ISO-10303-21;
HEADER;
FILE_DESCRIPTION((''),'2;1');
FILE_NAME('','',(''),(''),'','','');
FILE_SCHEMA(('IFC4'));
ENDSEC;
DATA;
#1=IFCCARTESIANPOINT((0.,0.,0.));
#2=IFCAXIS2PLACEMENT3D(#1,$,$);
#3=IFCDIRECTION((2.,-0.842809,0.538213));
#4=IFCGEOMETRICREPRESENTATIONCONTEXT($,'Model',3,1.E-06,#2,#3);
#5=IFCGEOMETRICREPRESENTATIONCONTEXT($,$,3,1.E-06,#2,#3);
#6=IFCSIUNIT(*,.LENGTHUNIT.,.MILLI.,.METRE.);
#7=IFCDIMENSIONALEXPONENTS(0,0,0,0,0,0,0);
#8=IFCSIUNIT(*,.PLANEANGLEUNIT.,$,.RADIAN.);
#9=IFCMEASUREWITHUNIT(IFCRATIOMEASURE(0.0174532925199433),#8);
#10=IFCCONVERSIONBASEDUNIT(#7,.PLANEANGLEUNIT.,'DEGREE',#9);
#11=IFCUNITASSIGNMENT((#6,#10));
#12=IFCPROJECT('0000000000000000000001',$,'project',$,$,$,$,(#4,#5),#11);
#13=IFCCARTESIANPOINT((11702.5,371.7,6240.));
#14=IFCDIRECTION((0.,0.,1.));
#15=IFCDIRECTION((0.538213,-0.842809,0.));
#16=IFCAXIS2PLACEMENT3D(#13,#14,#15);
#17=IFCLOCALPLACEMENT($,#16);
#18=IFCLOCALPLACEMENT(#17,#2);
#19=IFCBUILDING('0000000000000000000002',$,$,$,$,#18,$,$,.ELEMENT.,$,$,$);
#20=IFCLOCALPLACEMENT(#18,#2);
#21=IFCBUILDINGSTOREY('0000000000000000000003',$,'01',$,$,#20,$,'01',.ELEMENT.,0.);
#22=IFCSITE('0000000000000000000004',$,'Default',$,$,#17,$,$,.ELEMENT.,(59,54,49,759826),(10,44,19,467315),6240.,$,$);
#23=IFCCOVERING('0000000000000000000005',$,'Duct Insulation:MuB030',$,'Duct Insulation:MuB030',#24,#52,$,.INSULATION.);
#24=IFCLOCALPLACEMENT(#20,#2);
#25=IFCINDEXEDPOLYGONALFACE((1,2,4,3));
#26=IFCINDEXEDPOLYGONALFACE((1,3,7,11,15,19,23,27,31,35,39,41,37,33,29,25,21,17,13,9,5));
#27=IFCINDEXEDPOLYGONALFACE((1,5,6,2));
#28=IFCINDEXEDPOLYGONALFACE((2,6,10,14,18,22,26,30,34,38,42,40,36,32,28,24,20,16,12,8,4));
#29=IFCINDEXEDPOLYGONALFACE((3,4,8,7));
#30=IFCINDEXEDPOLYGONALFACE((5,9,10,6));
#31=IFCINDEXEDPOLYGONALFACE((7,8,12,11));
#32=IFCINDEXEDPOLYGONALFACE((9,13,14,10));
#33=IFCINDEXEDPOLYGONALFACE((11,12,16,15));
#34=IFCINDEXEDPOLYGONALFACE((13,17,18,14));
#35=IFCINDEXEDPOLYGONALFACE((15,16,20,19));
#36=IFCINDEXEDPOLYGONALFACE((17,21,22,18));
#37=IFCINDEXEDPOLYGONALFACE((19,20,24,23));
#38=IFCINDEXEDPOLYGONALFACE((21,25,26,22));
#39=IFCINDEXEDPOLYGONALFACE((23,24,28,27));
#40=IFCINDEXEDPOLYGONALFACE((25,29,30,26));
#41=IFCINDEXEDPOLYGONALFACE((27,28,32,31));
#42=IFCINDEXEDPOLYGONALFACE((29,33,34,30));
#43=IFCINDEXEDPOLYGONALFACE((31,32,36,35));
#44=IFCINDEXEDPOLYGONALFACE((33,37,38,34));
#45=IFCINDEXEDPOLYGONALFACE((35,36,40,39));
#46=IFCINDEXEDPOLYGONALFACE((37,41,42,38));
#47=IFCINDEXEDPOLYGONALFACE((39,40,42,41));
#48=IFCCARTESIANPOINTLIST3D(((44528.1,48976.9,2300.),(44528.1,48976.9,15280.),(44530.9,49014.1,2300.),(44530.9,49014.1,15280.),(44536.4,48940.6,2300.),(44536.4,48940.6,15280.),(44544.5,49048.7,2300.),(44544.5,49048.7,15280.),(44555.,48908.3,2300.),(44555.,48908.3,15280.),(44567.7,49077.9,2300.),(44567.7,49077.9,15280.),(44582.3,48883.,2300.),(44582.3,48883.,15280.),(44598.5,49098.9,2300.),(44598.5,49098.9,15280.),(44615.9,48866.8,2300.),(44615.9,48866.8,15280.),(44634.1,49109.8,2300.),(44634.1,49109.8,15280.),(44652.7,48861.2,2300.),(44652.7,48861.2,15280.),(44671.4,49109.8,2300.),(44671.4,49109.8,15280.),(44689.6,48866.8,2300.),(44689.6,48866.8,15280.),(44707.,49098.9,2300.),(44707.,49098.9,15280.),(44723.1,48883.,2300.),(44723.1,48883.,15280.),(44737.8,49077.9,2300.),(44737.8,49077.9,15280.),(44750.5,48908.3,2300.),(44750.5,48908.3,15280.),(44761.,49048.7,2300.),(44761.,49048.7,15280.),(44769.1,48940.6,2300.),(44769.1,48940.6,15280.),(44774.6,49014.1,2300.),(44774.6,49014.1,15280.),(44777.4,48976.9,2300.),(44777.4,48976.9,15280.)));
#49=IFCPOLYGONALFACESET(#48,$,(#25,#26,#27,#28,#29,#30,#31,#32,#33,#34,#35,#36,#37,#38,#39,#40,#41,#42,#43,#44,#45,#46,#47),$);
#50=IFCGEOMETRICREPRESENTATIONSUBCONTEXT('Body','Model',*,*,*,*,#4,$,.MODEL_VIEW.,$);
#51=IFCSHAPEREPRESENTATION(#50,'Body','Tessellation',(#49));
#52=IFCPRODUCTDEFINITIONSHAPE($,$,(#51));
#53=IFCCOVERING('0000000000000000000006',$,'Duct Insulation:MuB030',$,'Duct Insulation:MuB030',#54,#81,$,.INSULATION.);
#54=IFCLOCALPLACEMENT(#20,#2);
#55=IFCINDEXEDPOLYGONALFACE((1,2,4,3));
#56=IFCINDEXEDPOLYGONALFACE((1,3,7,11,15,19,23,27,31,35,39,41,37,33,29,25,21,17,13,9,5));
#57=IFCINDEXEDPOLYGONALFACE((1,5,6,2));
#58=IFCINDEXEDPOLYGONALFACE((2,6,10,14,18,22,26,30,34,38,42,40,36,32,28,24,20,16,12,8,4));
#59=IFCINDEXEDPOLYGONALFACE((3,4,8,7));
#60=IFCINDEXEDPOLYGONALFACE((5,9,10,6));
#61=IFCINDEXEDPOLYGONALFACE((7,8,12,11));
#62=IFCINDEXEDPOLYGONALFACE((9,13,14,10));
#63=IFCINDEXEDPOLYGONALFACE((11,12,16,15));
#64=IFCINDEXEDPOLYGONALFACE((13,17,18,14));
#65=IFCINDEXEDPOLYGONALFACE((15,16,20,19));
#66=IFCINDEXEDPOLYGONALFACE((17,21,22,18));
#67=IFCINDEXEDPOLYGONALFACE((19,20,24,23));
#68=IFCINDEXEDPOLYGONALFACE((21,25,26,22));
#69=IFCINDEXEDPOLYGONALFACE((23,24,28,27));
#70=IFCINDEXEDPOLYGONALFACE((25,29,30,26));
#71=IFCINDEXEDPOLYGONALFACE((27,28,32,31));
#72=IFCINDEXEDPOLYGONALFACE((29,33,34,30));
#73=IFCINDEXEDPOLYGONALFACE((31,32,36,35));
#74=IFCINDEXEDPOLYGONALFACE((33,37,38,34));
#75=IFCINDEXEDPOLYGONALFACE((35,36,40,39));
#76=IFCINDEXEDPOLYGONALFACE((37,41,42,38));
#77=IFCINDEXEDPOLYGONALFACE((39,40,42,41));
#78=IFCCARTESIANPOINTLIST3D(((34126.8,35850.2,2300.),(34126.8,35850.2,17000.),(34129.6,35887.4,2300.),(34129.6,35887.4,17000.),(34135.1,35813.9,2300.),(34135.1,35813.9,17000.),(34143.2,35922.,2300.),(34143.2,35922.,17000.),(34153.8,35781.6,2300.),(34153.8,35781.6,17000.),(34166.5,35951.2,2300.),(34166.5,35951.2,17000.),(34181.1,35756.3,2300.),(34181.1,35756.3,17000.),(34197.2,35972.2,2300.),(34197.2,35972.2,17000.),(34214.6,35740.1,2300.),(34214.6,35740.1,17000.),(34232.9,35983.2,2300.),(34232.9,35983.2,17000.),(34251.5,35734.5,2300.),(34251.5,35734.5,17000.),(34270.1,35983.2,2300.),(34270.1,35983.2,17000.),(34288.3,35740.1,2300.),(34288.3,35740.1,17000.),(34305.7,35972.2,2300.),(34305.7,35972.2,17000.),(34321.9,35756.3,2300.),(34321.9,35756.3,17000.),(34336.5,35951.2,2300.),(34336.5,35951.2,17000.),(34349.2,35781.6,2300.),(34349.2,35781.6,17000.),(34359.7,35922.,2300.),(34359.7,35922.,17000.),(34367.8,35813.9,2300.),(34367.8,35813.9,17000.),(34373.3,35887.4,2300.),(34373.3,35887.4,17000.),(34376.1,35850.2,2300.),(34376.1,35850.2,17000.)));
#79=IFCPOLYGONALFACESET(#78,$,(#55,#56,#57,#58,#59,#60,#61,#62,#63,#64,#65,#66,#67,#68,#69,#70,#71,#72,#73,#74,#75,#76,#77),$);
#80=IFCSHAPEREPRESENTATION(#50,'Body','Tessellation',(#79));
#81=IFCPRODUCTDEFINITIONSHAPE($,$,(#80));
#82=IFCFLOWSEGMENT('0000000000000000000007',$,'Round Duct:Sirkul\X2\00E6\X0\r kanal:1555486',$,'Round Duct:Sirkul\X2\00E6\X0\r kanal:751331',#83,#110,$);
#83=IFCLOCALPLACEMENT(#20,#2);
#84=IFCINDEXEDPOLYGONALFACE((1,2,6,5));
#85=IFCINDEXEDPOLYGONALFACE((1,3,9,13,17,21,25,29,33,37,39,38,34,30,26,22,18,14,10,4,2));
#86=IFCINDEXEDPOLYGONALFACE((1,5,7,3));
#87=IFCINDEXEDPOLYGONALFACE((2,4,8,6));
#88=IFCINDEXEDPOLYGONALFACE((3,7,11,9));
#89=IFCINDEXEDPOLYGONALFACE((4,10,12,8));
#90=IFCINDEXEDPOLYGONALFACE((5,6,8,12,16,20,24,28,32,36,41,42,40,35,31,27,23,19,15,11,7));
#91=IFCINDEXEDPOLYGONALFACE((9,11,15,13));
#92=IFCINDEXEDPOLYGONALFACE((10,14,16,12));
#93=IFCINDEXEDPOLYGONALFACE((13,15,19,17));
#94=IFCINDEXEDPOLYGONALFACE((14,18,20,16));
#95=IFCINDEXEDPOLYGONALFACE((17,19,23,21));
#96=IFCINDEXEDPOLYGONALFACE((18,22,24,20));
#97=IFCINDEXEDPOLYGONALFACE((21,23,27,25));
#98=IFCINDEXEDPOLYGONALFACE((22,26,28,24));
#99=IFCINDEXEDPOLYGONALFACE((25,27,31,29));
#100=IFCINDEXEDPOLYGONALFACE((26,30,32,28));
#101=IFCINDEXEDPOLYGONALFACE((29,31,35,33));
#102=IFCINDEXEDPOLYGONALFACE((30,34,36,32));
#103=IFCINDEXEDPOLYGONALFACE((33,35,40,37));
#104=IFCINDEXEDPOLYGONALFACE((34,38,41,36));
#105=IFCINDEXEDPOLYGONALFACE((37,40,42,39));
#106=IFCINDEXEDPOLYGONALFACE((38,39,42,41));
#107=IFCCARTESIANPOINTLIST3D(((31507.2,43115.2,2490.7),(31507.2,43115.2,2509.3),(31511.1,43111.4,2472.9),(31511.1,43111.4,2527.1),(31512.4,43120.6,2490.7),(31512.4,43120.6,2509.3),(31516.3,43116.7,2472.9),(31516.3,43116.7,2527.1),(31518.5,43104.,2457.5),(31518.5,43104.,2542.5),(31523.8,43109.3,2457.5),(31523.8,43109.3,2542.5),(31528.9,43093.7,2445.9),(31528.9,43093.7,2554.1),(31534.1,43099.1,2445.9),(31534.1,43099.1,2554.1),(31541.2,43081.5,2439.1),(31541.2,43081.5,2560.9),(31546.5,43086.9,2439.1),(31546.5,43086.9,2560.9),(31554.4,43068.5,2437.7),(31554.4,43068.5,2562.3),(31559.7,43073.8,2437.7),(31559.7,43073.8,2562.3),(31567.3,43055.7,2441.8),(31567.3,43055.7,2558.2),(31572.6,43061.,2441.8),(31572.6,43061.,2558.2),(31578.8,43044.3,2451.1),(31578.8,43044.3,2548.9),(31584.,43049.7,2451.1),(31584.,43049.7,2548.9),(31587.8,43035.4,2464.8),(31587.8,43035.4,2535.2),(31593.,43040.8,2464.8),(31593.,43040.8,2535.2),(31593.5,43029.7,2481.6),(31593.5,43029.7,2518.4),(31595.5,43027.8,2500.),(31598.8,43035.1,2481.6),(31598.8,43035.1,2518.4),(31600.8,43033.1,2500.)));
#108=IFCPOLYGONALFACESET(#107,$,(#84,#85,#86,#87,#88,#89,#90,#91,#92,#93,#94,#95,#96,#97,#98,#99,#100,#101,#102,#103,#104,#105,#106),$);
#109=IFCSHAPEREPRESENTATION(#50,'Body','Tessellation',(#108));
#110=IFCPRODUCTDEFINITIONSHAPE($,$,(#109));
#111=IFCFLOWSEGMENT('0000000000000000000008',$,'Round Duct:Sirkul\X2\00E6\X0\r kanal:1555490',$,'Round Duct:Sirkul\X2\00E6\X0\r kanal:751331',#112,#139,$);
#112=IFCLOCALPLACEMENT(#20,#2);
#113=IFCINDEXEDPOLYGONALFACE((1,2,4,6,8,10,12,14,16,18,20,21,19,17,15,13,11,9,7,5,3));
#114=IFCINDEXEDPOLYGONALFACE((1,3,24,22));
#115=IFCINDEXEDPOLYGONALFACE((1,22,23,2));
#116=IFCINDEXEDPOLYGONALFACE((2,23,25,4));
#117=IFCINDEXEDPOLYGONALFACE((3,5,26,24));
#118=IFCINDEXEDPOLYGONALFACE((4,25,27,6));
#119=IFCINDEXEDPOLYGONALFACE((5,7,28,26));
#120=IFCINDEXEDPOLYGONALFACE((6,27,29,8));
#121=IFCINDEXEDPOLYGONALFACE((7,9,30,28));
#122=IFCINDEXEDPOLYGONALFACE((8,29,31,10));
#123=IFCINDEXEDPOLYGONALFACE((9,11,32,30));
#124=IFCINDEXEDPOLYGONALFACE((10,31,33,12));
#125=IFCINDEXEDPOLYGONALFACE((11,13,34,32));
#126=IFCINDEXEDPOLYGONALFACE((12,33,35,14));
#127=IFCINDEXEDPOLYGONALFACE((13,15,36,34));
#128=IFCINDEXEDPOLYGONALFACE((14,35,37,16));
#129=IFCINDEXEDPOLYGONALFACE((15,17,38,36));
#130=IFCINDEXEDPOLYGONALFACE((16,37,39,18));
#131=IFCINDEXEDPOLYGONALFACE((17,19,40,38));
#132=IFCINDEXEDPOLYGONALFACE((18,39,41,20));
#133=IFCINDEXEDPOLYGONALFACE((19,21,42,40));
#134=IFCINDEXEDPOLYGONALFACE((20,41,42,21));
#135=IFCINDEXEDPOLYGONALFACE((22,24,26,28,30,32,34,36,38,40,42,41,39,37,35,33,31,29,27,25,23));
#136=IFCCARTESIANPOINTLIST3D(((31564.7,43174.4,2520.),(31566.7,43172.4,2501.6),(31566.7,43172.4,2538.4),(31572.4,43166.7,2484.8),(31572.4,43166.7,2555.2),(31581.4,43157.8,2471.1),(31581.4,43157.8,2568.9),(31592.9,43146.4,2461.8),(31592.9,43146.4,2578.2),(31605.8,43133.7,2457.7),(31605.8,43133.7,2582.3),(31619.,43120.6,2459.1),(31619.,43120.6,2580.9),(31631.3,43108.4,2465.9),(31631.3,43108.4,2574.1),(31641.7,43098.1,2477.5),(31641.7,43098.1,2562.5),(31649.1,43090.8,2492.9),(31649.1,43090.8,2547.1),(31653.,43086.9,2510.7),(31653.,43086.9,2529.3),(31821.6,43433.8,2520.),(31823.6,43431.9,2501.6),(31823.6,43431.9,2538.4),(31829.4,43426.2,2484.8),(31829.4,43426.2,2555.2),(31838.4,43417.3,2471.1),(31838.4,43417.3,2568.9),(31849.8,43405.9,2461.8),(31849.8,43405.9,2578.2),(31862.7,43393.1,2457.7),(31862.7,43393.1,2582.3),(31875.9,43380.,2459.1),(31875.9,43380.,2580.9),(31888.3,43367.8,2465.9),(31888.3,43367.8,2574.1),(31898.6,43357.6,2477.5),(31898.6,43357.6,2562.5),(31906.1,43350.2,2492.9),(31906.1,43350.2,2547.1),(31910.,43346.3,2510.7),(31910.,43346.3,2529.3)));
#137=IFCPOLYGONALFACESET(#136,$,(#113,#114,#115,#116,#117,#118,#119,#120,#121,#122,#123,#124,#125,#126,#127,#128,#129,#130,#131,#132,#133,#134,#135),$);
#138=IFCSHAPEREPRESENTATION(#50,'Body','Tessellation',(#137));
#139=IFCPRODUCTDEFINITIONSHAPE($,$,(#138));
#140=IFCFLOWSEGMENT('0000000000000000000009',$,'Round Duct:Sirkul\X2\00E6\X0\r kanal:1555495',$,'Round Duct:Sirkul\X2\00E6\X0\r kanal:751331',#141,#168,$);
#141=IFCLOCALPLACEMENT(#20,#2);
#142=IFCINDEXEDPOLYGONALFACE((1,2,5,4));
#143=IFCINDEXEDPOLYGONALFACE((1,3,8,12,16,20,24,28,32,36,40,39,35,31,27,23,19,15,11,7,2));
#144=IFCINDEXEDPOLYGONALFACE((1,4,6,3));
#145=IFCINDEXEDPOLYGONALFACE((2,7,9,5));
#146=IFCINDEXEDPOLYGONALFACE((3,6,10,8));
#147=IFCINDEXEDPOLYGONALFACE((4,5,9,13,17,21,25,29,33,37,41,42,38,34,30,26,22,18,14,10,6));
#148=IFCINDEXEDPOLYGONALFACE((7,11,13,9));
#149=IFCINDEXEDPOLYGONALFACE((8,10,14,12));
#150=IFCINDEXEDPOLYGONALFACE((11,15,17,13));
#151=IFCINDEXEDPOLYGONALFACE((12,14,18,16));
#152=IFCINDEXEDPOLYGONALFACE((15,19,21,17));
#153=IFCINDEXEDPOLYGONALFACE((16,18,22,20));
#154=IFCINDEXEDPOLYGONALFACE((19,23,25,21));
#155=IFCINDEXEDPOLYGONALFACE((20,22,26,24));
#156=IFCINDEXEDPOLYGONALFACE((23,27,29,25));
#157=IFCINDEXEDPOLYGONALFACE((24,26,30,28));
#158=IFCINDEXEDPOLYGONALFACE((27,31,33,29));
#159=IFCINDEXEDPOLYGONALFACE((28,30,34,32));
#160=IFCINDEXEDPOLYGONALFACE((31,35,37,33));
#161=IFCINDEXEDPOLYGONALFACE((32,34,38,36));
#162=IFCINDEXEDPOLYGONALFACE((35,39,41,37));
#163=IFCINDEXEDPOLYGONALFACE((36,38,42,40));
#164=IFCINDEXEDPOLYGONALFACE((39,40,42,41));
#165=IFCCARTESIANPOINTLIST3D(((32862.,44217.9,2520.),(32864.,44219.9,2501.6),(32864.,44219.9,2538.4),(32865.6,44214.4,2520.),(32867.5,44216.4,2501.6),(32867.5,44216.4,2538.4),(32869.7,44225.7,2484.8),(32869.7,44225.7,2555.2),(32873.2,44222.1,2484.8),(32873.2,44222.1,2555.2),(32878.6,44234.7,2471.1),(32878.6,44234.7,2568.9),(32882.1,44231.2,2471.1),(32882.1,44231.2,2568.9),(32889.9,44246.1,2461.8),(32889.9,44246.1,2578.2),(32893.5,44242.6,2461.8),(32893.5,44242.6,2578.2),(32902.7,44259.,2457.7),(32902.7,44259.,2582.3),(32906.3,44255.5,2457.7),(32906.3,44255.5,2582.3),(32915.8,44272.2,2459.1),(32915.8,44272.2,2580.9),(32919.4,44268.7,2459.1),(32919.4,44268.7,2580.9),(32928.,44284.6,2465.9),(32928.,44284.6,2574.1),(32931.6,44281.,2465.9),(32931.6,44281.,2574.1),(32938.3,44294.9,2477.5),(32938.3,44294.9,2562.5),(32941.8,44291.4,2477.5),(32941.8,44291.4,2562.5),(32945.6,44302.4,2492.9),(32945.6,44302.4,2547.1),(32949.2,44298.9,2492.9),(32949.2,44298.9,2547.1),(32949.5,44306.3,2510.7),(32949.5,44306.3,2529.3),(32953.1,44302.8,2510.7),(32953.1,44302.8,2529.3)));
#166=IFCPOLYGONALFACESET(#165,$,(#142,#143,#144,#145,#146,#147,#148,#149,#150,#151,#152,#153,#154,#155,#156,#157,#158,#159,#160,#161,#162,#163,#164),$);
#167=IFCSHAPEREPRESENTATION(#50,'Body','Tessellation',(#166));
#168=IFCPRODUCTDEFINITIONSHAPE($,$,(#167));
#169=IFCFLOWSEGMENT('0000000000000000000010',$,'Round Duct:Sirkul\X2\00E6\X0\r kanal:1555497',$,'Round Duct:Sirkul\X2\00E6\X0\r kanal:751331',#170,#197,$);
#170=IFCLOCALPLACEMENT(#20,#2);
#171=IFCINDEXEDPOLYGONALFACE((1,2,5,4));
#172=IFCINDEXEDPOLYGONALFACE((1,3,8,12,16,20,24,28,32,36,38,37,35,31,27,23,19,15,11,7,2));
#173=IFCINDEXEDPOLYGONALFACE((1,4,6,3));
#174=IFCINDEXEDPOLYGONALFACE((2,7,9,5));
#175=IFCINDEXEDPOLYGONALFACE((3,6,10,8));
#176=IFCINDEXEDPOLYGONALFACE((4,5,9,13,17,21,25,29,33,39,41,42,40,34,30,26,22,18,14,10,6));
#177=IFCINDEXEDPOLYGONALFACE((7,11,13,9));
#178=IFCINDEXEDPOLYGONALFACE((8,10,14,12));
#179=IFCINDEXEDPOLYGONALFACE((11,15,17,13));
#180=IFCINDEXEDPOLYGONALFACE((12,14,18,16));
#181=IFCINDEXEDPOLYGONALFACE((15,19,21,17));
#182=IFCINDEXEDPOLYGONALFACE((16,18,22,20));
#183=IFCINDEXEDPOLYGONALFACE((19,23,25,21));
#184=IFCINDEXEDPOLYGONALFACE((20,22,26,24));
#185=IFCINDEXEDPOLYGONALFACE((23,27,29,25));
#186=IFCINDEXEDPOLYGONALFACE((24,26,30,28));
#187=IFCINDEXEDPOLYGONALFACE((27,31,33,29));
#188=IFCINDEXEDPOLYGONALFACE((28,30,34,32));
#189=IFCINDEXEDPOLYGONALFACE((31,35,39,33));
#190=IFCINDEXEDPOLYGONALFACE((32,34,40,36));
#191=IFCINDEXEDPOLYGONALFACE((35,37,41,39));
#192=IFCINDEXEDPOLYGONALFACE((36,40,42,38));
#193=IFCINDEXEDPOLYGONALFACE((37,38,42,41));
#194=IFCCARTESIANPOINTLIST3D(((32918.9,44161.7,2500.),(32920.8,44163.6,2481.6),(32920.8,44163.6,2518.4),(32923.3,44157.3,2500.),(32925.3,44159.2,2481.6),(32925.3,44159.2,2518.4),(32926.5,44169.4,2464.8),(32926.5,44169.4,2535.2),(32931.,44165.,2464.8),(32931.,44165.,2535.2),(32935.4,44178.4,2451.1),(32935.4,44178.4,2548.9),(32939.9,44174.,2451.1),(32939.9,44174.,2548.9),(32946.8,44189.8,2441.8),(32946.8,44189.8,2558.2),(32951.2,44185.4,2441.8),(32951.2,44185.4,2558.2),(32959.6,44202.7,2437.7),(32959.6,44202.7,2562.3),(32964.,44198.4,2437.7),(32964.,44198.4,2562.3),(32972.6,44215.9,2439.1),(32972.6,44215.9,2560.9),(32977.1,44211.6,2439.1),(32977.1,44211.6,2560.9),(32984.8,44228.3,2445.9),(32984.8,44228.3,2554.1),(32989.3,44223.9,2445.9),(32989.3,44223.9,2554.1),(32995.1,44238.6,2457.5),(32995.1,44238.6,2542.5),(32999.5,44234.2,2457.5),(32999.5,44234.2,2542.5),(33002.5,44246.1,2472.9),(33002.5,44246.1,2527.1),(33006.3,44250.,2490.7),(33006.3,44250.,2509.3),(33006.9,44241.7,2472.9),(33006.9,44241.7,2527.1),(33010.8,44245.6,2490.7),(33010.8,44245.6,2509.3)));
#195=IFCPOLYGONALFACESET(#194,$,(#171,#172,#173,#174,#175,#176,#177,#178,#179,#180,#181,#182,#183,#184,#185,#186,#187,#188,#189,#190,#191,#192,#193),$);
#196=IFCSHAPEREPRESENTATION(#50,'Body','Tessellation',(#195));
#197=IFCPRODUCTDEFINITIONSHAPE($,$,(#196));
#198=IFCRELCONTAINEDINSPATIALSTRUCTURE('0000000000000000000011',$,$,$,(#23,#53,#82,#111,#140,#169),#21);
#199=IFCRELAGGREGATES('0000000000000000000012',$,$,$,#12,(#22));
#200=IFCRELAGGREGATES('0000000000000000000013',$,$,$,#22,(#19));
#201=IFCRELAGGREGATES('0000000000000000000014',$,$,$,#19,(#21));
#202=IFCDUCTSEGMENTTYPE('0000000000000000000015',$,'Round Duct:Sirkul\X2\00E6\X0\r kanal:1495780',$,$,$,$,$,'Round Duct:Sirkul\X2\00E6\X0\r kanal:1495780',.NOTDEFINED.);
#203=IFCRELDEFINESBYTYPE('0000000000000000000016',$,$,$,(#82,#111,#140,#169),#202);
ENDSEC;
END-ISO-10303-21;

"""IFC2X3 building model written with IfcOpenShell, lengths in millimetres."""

from ifc_helpers import new_model, entity, si_unit, converted_unit, direction, frame, origin, origin_2d_with_axis, place, context, subcontext, project, spatial, circle, extrude, type_object, element, save


model = new_model("IFC2X3")

# Units and contexts
model_context = context("Model", 3, precision=1e-06, world=origin(), true_north=direction((2.0, -0.842809, 0.538213)))
context_of_model = context(None, 3, precision=1e-06, world=origin(), true_north=direction((2.0, -0.842809, 0.538213)))
body_context = subcontext(model_context, "Body", "Model", "MODEL_VIEW")
ifc_project = project(units=[si_unit("LENGTHUNIT", "METRE", prefix="MILLI"), converted_unit("PLANEANGLEUNIT", "DEGREE", entity("IfcRatioMeasure", 0.0174532925199433), si_unit("PLANEANGLEUNIT", "RADIAN"), dimensions=[0, 0, 0, 0, 0, 0, 0])], contexts=[model_context, context_of_model])

# Site, building, storey
site_placement = place(None, frame((11702.5, 371.7, 6240.0), z_axis=(0.0, 0.0, 1.0), x_axis=(0.538213, -0.842809, 0.0)))
site = spatial("IfcSite", under=ifc_project, at=site_placement, Name="Default", CompositionType="ELEMENT", RefLatitude=(59, 54, 49, 759826), RefLongitude=(10, 44, 19, 467315), RefElevation=6240.0)
building_placement = place(site_placement, origin())
building = spatial("IfcBuilding", under=site, at=building_placement, CompositionType="ELEMENT")
storey_placement = place(building_placement, origin())
storey = spatial("IfcBuildingStorey", under=building, at=storey_placement, Name="01", LongName="01", CompositionType="ELEMENT", Elevation=0.0)

# Coverings
covering_1_placement = place(storey_placement, origin())
element("IfcCovering", 1, at=covering_1_placement, inside=storey, Name="Duct Insulation:MuB030", ObjectType="Duct Insulation:MuB030", PredefinedType="INSULATION", context=body_context, shape_type="SweptSolid", body=[
    extrude(circle(Radius=125.0, at=origin_2d_with_axis()), frame((44652.7, 48986.2, 2300.0), z_axis=(0.0, 0.0, 1.0), x_axis=(0.0, -1.0, 0.0)), (0.0, 0.0, 1.0), 12980.0),
])
covering_2_placement = place(storey_placement, origin())
element("IfcCovering", 2, at=covering_2_placement, inside=storey, Name="Duct Insulation:MuB030", ObjectType="Duct Insulation:MuB030", PredefinedType="INSULATION", context=body_context, shape_type="SweptSolid", body=[
    extrude(circle(Radius=125.0, at=origin_2d_with_axis()), frame((34251.5, 35859.5, 2300.0), z_axis=(0.0, 0.0, 1.0), x_axis=(0.0, -1.0, 0.0)), (0.0, 0.0, 1.0), 14700.0),
])

# Flow segments
duct_segment_type = type_object("IfcDuctSegmentType", Name="Round Duct:Sirkulær kanal:1495780", ElementType="Round Duct:Sirkulær kanal:1495780", PredefinedType="NOTDEFINED")
flow_segment_1_placement = place(storey_placement, origin())
element("IfcFlowSegment", 3, at=flow_segment_1_placement, inside=storey, type_object=duct_segment_type, Name="Round Duct:Sirkulær kanal:1555486", ObjectType="Round Duct:Sirkulær kanal:751331", context=body_context, shape_type="SweptSolid", body=[
    extrude(circle(Radius=62.5, at=origin_2d_with_axis()), frame((31551.1, 43071.8, 2500.0), z_axis=(0.703643, 0.710554, 0.0), x_axis=(0.710554, -0.703643, 0.0)), (0.0, 0.0, 1.0), 7.5),
])
flow_segment_2_placement = place(storey_placement, origin())
element("IfcFlowSegment", 4, at=flow_segment_2_placement, inside=storey, type_object=duct_segment_type, Name="Round Duct:Sirkulær kanal:1555490", ObjectType="Round Duct:Sirkulær kanal:751331", context=body_context, shape_type="SweptSolid", body=[
    extrude(circle(Radius=62.5, at=origin_2d_with_axis()), frame((31609.1, 43130.4, 2520.0), z_axis=(0.703643, 0.710554, 0.0), x_axis=(-0.710554, 0.703643, 0.0)), (0.0, 0.0, 1.0), 365.1),
])
flow_segment_3_placement = place(storey_placement, origin())
element("IfcFlowSegment", 5, at=flow_segment_3_placement, inside=storey, type_object=duct_segment_type, Name="Round Duct:Sirkulær kanal:1555495", ObjectType="Round Duct:Sirkulær kanal:751331", context=body_context, shape_type="SweptSolid", body=[
    extrude(circle(Radius=62.5, at=origin_2d_with_axis()), frame((32906.0, 44262.4, 2520.0), z_axis=(0.710554, -0.703643, 0.0), x_axis=(-0.703643, -0.710554, 0.0)), (0.0, 0.0, 1.0), 5.0),
])
flow_segment_4_placement = place(storey_placement, origin())
element("IfcFlowSegment", 6, at=flow_segment_4_placement, inside=storey, type_object=duct_segment_type, Name="Round Duct:Sirkulær kanal:1555497", ObjectType="Round Duct:Sirkulær kanal:751331", context=body_context, shape_type="SweptSolid", body=[
    extrude(circle(Radius=62.5, at=origin_2d_with_axis()), frame((32967.3, 44201.7, 2500.0), z_axis=(-0.710554, 0.703643, 0.0), x_axis=(-0.703643, -0.710554, 0.0)), (0.0, 0.0, 1.0), 6.2),
])

save(model, "model.ifc")
